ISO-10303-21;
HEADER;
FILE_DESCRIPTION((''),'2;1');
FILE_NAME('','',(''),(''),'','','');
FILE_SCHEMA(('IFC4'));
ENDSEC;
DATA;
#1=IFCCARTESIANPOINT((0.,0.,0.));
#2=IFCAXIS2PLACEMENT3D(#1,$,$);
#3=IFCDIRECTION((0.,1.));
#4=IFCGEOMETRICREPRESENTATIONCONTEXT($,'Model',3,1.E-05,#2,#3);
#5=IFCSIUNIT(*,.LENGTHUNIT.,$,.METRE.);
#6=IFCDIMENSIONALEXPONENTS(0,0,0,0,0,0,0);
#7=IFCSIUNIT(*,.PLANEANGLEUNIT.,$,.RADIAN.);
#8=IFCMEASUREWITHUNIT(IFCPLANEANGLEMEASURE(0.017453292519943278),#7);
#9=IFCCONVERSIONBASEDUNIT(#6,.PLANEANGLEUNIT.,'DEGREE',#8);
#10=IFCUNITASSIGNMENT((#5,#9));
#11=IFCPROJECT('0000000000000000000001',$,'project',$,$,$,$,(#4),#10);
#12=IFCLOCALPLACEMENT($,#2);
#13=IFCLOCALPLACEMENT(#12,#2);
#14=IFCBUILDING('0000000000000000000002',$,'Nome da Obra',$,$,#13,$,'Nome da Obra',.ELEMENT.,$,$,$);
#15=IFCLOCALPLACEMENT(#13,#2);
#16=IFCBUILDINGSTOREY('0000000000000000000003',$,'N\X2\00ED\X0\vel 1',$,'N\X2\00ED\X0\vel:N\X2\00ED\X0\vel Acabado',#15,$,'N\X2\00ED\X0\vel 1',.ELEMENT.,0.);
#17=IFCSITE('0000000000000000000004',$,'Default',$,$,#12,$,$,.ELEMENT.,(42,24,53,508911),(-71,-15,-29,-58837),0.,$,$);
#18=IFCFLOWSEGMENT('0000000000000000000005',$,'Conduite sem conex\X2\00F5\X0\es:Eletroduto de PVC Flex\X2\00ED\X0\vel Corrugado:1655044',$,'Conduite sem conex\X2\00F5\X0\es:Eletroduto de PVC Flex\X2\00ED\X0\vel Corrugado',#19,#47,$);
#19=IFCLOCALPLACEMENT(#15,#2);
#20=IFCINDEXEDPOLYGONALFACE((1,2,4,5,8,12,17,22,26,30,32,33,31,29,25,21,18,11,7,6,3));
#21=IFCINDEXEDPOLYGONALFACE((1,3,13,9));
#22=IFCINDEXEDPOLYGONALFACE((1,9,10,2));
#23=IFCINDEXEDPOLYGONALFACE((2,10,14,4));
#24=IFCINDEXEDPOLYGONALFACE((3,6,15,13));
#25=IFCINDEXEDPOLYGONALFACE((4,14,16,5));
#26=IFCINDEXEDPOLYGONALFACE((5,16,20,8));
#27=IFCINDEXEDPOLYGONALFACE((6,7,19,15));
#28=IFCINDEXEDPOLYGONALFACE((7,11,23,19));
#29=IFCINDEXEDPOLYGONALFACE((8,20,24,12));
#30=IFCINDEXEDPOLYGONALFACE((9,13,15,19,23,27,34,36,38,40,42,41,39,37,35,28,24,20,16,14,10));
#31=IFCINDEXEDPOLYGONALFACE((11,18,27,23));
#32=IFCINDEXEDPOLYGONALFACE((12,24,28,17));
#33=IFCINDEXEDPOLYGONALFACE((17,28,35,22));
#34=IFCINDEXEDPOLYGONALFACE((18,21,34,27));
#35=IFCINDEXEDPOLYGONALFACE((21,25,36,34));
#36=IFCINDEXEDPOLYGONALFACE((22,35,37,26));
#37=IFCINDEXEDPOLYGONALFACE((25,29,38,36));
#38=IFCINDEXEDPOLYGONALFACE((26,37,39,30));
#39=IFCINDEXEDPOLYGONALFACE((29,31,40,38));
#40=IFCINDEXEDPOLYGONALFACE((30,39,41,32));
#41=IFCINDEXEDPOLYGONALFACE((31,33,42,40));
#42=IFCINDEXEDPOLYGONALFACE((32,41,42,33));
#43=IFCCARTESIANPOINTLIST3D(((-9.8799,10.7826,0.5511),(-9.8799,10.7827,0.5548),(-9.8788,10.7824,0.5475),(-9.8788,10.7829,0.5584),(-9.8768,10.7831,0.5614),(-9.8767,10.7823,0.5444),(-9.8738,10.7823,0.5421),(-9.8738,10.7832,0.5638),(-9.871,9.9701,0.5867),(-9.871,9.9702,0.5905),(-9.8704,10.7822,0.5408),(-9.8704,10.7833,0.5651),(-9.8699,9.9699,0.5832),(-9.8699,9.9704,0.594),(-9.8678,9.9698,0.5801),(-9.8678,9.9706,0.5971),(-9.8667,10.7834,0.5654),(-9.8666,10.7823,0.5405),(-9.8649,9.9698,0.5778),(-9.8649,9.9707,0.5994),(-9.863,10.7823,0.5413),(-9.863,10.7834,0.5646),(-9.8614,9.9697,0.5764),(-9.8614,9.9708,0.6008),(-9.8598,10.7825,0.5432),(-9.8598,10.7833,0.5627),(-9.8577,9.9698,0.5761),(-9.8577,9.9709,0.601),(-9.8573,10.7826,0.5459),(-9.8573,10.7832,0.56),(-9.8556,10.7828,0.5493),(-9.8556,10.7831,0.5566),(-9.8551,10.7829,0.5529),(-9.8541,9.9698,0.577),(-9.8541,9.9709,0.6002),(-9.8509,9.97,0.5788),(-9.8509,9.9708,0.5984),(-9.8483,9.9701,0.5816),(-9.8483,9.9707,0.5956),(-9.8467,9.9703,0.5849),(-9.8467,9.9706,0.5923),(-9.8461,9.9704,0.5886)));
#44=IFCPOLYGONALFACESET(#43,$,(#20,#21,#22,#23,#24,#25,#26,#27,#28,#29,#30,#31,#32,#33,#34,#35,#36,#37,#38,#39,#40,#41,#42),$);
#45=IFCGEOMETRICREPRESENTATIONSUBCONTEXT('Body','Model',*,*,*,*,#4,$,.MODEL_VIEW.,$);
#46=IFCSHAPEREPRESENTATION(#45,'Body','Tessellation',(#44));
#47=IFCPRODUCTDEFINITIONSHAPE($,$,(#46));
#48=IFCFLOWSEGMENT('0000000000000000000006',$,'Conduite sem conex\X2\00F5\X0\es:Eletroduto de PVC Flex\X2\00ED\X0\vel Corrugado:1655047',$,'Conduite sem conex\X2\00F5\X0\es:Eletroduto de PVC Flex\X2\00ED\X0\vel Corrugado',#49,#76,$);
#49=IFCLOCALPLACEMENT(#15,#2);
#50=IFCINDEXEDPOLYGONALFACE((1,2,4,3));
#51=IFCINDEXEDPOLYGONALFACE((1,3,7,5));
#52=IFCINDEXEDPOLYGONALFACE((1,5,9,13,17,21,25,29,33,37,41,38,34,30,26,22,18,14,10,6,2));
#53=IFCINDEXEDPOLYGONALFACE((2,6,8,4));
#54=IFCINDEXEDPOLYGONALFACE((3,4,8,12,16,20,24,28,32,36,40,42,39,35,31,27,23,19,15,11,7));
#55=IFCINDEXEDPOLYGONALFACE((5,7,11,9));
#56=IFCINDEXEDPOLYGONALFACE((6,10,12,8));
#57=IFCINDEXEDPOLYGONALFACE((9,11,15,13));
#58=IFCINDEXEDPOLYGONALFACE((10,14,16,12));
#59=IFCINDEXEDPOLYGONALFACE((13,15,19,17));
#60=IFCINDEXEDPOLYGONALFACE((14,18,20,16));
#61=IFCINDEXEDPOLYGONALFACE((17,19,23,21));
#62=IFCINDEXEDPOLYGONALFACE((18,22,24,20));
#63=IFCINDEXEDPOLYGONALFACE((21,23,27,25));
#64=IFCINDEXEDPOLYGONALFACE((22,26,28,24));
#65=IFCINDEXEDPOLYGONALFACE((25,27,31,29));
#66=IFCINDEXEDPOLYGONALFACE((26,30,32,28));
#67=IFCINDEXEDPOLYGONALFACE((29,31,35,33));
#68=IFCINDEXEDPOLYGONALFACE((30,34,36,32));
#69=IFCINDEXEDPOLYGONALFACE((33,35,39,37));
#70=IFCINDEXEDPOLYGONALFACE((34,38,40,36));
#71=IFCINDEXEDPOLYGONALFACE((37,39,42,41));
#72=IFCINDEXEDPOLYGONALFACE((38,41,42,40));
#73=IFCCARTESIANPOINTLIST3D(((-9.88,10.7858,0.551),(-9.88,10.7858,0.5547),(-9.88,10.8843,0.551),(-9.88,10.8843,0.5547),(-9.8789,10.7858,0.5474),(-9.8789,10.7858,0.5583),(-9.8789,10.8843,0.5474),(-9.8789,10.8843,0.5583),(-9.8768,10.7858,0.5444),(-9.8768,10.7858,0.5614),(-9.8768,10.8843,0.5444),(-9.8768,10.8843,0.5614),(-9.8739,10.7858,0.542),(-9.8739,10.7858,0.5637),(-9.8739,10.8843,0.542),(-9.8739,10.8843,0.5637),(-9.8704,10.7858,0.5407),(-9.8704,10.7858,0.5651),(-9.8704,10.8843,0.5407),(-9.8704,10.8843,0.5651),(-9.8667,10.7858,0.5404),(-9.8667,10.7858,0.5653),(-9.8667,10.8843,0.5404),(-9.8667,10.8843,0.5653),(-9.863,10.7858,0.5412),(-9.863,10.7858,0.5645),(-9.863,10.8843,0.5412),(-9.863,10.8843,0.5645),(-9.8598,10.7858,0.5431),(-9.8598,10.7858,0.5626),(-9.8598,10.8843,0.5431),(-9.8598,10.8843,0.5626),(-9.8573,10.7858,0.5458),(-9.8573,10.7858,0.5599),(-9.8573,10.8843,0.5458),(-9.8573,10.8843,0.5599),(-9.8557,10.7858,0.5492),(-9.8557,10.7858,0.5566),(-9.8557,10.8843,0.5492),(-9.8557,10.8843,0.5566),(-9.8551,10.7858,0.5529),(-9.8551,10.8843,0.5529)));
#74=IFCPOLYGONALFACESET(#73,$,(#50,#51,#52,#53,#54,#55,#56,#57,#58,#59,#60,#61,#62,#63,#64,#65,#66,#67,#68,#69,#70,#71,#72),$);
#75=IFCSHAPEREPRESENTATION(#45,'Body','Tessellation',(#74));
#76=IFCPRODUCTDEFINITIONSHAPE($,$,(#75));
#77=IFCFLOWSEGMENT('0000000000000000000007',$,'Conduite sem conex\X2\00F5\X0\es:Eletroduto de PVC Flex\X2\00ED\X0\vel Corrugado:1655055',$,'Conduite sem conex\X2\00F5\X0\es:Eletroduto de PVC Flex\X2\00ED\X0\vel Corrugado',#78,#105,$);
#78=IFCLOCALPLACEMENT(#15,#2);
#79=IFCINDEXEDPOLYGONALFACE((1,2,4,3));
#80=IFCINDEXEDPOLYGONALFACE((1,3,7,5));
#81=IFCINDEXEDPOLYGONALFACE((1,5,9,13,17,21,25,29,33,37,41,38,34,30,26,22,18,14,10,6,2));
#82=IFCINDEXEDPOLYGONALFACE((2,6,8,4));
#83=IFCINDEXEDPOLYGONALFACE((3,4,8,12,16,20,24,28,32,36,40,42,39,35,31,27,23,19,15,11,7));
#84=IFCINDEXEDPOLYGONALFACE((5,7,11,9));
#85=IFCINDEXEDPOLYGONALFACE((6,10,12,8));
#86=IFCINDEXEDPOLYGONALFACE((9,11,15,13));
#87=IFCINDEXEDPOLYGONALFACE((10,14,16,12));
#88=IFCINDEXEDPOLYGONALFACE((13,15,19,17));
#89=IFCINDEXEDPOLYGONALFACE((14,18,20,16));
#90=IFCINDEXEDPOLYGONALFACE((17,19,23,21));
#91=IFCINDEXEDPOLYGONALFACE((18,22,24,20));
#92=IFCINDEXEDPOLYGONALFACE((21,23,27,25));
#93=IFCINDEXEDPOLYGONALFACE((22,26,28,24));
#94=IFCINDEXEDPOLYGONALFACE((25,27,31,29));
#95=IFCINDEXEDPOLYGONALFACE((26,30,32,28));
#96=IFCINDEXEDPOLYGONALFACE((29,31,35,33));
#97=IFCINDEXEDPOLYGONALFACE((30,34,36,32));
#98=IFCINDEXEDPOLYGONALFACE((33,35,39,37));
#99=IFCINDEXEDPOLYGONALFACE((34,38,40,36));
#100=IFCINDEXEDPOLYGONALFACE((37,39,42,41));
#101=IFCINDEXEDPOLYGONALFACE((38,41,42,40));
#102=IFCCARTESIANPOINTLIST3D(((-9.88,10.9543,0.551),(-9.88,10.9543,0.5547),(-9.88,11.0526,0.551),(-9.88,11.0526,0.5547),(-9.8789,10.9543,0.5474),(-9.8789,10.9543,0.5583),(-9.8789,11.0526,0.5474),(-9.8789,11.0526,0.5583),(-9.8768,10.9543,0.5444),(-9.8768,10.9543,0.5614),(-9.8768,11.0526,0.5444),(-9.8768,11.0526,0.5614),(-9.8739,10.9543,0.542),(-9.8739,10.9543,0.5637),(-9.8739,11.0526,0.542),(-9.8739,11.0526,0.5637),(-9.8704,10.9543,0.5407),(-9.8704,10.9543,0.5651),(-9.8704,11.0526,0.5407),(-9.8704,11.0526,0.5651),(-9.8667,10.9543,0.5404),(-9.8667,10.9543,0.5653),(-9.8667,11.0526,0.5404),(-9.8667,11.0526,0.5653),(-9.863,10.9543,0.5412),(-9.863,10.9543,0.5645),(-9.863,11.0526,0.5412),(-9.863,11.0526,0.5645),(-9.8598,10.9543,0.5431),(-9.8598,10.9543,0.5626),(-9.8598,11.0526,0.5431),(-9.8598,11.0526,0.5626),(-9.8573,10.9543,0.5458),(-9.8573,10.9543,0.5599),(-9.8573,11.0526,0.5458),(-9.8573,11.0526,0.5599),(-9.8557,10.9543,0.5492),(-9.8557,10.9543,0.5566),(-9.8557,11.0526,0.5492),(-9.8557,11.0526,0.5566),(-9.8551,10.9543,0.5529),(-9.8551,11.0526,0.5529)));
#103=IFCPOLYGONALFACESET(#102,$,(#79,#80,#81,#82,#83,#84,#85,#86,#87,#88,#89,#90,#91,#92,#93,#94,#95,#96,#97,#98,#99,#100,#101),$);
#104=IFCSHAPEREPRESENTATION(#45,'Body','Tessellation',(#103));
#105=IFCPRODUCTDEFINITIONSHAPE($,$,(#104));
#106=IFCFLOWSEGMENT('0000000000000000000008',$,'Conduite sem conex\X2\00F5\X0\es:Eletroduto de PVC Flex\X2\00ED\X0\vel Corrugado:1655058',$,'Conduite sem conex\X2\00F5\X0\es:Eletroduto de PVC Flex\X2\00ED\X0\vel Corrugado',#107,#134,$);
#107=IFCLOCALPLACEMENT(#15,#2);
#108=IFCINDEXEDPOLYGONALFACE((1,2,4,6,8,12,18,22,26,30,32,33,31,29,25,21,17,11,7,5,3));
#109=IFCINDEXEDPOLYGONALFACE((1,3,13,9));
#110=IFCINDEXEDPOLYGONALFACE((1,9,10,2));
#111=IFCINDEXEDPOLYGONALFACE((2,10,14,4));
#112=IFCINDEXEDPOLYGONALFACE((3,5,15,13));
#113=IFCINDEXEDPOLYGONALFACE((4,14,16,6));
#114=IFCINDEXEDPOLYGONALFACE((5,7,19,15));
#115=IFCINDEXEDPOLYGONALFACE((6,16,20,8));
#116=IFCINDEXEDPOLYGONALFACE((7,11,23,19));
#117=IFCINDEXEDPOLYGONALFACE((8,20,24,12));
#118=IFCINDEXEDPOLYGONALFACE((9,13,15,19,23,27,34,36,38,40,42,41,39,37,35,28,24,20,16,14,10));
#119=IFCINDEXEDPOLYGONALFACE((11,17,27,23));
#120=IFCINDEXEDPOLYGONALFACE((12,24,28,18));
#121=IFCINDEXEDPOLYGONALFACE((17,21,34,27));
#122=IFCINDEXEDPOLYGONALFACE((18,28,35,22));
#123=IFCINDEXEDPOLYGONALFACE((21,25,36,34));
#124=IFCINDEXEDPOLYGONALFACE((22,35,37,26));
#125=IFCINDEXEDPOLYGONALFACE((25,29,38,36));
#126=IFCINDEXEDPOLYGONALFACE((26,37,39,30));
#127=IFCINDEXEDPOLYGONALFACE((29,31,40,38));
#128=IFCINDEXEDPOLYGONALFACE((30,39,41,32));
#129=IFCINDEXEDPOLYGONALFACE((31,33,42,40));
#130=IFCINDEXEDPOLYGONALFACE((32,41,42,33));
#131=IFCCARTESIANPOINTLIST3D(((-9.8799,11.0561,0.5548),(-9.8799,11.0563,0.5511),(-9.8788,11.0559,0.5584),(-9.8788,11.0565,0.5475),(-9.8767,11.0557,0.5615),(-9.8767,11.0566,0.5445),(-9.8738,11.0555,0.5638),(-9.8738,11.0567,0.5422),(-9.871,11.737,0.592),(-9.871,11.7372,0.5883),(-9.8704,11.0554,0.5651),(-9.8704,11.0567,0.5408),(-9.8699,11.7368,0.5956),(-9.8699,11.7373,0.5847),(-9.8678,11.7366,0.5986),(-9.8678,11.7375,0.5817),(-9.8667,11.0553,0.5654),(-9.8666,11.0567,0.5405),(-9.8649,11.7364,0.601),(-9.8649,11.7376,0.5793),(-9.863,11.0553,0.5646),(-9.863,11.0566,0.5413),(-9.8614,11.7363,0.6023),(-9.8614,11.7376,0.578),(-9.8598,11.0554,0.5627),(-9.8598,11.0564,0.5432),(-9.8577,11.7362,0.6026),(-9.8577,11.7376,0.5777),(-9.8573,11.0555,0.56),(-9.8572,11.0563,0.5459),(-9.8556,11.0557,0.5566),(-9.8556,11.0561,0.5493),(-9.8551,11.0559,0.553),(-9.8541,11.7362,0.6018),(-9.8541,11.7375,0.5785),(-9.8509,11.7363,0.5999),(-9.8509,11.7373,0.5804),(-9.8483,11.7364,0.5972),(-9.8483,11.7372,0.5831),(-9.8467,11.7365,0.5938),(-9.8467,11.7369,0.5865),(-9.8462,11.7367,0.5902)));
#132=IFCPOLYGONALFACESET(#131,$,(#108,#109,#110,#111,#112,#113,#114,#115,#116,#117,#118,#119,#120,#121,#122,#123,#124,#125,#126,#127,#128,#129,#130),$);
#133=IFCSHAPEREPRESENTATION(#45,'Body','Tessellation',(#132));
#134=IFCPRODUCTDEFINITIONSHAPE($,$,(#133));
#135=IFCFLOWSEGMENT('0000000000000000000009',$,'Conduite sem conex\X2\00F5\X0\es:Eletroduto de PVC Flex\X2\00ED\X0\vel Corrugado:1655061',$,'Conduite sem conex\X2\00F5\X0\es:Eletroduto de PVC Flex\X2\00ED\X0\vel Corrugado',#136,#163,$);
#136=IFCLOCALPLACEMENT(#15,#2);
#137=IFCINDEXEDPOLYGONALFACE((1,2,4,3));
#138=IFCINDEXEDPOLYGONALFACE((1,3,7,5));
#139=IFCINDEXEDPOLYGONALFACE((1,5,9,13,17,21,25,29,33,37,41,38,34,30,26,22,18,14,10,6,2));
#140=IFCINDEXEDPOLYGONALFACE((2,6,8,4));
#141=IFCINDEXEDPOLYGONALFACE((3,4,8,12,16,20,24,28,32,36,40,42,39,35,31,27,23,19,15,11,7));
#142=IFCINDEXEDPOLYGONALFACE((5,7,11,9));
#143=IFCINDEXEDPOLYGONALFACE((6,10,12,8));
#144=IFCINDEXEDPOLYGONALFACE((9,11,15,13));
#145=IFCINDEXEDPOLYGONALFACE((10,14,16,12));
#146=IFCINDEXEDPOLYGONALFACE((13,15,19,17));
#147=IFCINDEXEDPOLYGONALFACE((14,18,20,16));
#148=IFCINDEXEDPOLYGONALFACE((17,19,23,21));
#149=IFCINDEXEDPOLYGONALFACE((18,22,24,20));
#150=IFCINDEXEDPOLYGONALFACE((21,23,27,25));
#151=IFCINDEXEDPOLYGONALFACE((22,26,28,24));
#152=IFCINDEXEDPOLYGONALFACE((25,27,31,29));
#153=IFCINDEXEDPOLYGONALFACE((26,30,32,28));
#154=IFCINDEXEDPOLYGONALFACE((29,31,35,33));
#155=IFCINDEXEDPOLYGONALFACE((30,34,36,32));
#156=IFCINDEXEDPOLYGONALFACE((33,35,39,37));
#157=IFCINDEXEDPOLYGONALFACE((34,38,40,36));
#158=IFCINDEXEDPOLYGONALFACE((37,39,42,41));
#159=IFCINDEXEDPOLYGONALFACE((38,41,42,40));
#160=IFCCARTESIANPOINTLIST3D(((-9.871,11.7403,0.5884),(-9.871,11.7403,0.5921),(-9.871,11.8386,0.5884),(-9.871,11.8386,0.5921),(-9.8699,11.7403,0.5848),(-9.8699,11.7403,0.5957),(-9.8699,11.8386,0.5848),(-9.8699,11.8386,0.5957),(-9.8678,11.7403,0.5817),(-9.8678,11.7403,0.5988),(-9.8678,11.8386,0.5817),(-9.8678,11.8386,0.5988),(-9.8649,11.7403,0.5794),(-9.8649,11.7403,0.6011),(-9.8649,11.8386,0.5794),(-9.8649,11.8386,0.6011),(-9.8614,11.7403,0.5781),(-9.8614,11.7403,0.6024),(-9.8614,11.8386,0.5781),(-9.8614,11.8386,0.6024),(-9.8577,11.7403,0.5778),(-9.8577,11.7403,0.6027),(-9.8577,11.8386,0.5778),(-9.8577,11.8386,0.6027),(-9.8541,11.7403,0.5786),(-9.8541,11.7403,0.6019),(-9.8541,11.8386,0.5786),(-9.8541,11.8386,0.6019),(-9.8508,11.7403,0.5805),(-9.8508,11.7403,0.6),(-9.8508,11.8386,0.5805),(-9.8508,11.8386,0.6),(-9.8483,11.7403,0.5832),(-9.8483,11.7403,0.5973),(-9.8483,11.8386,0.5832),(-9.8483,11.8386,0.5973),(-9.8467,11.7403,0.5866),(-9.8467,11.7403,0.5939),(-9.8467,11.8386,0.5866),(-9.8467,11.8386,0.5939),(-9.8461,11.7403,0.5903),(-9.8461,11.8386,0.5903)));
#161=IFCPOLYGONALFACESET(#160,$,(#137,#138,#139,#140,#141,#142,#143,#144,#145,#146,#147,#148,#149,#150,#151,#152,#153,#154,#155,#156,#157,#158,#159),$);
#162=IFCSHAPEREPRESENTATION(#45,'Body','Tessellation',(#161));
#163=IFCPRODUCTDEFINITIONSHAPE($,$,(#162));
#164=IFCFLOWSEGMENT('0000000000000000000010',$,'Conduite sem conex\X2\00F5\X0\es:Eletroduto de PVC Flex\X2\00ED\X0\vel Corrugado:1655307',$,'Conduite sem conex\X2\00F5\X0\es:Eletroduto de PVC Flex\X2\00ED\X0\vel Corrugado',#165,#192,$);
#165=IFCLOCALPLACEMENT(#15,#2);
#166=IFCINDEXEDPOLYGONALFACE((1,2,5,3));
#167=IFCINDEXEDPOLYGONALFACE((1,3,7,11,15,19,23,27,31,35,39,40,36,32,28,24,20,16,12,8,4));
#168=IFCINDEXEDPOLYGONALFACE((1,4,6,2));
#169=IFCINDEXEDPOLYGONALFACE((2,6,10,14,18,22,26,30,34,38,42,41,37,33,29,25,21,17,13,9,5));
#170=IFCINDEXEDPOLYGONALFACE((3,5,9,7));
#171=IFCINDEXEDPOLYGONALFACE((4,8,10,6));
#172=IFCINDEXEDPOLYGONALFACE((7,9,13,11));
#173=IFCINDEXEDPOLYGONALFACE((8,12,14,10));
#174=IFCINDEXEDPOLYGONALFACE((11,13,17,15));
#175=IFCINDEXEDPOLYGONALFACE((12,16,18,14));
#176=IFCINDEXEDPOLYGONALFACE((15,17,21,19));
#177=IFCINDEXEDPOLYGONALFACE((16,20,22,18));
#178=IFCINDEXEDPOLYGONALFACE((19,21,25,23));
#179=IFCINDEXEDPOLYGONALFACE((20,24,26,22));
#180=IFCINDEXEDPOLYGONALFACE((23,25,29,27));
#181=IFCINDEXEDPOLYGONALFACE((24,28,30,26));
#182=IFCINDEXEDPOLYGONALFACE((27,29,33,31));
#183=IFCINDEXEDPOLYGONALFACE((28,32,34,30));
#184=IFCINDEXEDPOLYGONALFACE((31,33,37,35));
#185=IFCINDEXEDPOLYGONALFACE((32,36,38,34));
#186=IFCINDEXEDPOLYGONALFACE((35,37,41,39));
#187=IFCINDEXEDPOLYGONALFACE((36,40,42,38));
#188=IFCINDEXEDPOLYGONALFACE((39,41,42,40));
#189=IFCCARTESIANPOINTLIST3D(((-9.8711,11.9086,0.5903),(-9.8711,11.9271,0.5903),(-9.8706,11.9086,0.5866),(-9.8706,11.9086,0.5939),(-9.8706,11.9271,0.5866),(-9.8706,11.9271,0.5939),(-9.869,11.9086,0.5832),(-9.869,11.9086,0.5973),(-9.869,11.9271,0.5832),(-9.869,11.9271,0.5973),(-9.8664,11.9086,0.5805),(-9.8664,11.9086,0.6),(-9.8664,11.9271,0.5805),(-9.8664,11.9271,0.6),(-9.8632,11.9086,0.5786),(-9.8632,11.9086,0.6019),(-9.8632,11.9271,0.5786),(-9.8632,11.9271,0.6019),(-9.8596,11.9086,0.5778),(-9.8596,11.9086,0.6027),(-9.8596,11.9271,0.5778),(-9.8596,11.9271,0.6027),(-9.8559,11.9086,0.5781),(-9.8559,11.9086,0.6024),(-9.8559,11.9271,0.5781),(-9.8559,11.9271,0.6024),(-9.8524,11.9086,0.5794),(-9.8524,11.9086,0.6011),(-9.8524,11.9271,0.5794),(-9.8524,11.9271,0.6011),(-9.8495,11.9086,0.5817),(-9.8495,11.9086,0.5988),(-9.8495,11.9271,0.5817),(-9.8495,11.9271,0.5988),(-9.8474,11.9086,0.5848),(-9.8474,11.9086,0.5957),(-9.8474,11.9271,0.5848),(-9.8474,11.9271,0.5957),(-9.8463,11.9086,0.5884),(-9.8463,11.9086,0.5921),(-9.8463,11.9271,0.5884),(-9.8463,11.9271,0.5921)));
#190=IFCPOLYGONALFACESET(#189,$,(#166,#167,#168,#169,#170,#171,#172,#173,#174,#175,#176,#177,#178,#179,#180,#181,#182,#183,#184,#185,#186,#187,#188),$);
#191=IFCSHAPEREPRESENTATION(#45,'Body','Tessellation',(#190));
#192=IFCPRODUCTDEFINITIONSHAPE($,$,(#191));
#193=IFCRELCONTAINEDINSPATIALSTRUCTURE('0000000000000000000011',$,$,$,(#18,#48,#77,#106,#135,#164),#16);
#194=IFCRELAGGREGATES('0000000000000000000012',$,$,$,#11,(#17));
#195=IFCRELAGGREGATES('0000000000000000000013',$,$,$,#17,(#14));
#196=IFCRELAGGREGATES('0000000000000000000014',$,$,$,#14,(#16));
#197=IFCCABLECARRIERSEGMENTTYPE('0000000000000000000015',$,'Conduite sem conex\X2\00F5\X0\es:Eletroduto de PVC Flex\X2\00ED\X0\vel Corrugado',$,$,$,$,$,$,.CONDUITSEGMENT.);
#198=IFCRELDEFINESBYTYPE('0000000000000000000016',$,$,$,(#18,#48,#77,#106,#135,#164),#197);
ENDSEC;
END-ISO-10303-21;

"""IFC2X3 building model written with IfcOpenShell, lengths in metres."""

from ifc_helpers import new_model, entity, si_unit, converted_unit, direction, frame, frame_2d, origin, origin_2d_with_axis, place, context, subcontext, project, spatial, circle, extrude, type_object, element, save


model = new_model("IFC2X3")

# Units and contexts
model_context = context("Model", 3, precision=1e-05, world=origin(), true_north=direction((0.0, 1.0)))
body_context = subcontext(model_context, "Body", "Model", "MODEL_VIEW")
ifc_project = project(units=[si_unit("LENGTHUNIT", "METRE"), converted_unit("PLANEANGLEUNIT", "DEGREE", entity("IfcPlaneAngleMeasure", 0.017453292519943278), si_unit("PLANEANGLEUNIT", "RADIAN"), dimensions=[0, 0, 0, 0, 0, 0, 0])], contexts=[model_context])

# Site, building, storey
site_placement = place(None, origin())
site = spatial("IfcSite", under=ifc_project, at=site_placement, Name="Default", CompositionType="ELEMENT", RefLatitude=(42, 24, 53, 508911), RefLongitude=(-71, -15, -29, -58837), RefElevation=0.0)
building_placement = place(site_placement, origin())
building = spatial("IfcBuilding", under=site, at=building_placement, Name="Nome da Obra", LongName="Nome da Obra", CompositionType="ELEMENT")
storey_placement = place(building_placement, origin())
storey = spatial("IfcBuildingStorey", under=building, at=storey_placement, Name="Nível 1", ObjectType="Nível:Nível Acabado", LongName="Nível 1", CompositionType="ELEMENT", Elevation=0.0)

# Flow segments
cable_carrier_segment_type = type_object("IfcCableCarrierSegmentType", Name="Conduite sem conexões:Eletroduto de PVC Flexível Corrugado", PredefinedType="CONDUITSEGMENT")
flow_segment_1_placement = place(storey_placement, origin())
element("IfcFlowSegment", 1, at=flow_segment_1_placement, inside=storey, type_object=cable_carrier_segment_type, Name="Conduite sem conexões:Eletroduto de PVC Flexível Corrugado:1655044", ObjectType="Conduite sem conexões:Eletroduto de PVC Flexível Corrugado", context=body_context, shape_type="SweptSolid", body=[
    extrude(circle(Radius=0.0125, at=frame_2d((0.0, 0.0), x_axis=(1.0, 0.0))), frame((-9.8676, 10.7828, 0.5529), z_axis=(0.010986, -0.998978, 0.043834), x_axis=(0.99994, 0.010997, 0.0)), (0.0, 0.0, 1.0), 0.8133),
])
flow_segment_2_placement = place(storey_placement, origin())
element("IfcFlowSegment", 2, at=flow_segment_2_placement, inside=storey, type_object=cable_carrier_segment_type, Name="Conduite sem conexões:Eletroduto de PVC Flexível Corrugado:1655047", ObjectType="Conduite sem conexões:Eletroduto de PVC Flexível Corrugado", context=body_context, shape_type="SweptSolid", body=[
    extrude(circle(Radius=0.0125, at=origin_2d_with_axis()), frame((-9.8676, 10.7858, 0.5529), z_axis=(0.0, 1.0, 0.0), x_axis=(1.0, 0.0, 0.0)), (0.0, 0.0, 1.0), 0.0985),
])
flow_segment_3_placement = place(storey_placement, origin())
element("IfcFlowSegment", 3, at=flow_segment_3_placement, inside=storey, type_object=cable_carrier_segment_type, Name="Conduite sem conexões:Eletroduto de PVC Flexível Corrugado:1655055", ObjectType="Conduite sem conexões:Eletroduto de PVC Flexível Corrugado", context=body_context, shape_type="SweptSolid", body=[
    extrude(circle(Radius=0.0125, at=origin_2d_with_axis()), frame((-9.8676, 10.9543, 0.5529), z_axis=(0.0, 1.0, 0.0), x_axis=(1.0, 0.0, 0.0)), (0.0, 0.0, 1.0), 0.0983),
])
flow_segment_4_placement = place(storey_placement, origin())
element("IfcFlowSegment", 4, at=flow_segment_4_placement, inside=storey, type_object=cable_carrier_segment_type, Name="Conduite sem conexões:Eletroduto de PVC Flexível Corrugado:1655058", ObjectType="Conduite sem conexões:Eletroduto de PVC Flexível Corrugado", context=body_context, shape_type="SweptSolid", body=[
    extrude(circle(Radius=0.0125, at=frame_2d((0.0, 0.0), x_axis=(1.0, 0.0))), frame((-9.8676, 11.056, 0.553), z_axis=(0.013087, 0.998426, 0.054539), x_axis=(0.999914, -0.013106, 0.0)), (0.0, 0.0, 1.0), 0.682),
])
flow_segment_5_placement = place(storey_placement, origin())
element("IfcFlowSegment", 5, at=flow_segment_5_placement, inside=storey, type_object=cable_carrier_segment_type, Name="Conduite sem conexões:Eletroduto de PVC Flexível Corrugado:1655061", ObjectType="Conduite sem conexões:Eletroduto de PVC Flexível Corrugado", context=body_context, shape_type="SweptSolid", body=[
    extrude(circle(Radius=0.0125, at=origin_2d_with_axis()), frame((-9.8586, 11.7403, 0.5903), z_axis=(0.0, 1.0, 0.0), x_axis=(1.0, 0.0, 0.0)), (0.0, 0.0, 1.0), 0.0983),
])
flow_segment_6_placement = place(storey_placement, origin())
element("IfcFlowSegment", 6, at=flow_segment_6_placement, inside=storey, type_object=cable_carrier_segment_type, Name="Conduite sem conexões:Eletroduto de PVC Flexível Corrugado:1655307", ObjectType="Conduite sem conexões:Eletroduto de PVC Flexível Corrugado", context=body_context, shape_type="SweptSolid", body=[
    extrude(circle(Radius=0.0125, at=frame_2d((0.0, 0.0), x_axis=(1.0, 0.0))), frame((-9.8586, 11.9086, 0.5903), z_axis=(0.0, 1.0, 0.0), x_axis=(-1.0, 0.0, 0.0)), (0.0, 0.0, 1.0), 0.0185),
])

save(model, "model.ifc")
